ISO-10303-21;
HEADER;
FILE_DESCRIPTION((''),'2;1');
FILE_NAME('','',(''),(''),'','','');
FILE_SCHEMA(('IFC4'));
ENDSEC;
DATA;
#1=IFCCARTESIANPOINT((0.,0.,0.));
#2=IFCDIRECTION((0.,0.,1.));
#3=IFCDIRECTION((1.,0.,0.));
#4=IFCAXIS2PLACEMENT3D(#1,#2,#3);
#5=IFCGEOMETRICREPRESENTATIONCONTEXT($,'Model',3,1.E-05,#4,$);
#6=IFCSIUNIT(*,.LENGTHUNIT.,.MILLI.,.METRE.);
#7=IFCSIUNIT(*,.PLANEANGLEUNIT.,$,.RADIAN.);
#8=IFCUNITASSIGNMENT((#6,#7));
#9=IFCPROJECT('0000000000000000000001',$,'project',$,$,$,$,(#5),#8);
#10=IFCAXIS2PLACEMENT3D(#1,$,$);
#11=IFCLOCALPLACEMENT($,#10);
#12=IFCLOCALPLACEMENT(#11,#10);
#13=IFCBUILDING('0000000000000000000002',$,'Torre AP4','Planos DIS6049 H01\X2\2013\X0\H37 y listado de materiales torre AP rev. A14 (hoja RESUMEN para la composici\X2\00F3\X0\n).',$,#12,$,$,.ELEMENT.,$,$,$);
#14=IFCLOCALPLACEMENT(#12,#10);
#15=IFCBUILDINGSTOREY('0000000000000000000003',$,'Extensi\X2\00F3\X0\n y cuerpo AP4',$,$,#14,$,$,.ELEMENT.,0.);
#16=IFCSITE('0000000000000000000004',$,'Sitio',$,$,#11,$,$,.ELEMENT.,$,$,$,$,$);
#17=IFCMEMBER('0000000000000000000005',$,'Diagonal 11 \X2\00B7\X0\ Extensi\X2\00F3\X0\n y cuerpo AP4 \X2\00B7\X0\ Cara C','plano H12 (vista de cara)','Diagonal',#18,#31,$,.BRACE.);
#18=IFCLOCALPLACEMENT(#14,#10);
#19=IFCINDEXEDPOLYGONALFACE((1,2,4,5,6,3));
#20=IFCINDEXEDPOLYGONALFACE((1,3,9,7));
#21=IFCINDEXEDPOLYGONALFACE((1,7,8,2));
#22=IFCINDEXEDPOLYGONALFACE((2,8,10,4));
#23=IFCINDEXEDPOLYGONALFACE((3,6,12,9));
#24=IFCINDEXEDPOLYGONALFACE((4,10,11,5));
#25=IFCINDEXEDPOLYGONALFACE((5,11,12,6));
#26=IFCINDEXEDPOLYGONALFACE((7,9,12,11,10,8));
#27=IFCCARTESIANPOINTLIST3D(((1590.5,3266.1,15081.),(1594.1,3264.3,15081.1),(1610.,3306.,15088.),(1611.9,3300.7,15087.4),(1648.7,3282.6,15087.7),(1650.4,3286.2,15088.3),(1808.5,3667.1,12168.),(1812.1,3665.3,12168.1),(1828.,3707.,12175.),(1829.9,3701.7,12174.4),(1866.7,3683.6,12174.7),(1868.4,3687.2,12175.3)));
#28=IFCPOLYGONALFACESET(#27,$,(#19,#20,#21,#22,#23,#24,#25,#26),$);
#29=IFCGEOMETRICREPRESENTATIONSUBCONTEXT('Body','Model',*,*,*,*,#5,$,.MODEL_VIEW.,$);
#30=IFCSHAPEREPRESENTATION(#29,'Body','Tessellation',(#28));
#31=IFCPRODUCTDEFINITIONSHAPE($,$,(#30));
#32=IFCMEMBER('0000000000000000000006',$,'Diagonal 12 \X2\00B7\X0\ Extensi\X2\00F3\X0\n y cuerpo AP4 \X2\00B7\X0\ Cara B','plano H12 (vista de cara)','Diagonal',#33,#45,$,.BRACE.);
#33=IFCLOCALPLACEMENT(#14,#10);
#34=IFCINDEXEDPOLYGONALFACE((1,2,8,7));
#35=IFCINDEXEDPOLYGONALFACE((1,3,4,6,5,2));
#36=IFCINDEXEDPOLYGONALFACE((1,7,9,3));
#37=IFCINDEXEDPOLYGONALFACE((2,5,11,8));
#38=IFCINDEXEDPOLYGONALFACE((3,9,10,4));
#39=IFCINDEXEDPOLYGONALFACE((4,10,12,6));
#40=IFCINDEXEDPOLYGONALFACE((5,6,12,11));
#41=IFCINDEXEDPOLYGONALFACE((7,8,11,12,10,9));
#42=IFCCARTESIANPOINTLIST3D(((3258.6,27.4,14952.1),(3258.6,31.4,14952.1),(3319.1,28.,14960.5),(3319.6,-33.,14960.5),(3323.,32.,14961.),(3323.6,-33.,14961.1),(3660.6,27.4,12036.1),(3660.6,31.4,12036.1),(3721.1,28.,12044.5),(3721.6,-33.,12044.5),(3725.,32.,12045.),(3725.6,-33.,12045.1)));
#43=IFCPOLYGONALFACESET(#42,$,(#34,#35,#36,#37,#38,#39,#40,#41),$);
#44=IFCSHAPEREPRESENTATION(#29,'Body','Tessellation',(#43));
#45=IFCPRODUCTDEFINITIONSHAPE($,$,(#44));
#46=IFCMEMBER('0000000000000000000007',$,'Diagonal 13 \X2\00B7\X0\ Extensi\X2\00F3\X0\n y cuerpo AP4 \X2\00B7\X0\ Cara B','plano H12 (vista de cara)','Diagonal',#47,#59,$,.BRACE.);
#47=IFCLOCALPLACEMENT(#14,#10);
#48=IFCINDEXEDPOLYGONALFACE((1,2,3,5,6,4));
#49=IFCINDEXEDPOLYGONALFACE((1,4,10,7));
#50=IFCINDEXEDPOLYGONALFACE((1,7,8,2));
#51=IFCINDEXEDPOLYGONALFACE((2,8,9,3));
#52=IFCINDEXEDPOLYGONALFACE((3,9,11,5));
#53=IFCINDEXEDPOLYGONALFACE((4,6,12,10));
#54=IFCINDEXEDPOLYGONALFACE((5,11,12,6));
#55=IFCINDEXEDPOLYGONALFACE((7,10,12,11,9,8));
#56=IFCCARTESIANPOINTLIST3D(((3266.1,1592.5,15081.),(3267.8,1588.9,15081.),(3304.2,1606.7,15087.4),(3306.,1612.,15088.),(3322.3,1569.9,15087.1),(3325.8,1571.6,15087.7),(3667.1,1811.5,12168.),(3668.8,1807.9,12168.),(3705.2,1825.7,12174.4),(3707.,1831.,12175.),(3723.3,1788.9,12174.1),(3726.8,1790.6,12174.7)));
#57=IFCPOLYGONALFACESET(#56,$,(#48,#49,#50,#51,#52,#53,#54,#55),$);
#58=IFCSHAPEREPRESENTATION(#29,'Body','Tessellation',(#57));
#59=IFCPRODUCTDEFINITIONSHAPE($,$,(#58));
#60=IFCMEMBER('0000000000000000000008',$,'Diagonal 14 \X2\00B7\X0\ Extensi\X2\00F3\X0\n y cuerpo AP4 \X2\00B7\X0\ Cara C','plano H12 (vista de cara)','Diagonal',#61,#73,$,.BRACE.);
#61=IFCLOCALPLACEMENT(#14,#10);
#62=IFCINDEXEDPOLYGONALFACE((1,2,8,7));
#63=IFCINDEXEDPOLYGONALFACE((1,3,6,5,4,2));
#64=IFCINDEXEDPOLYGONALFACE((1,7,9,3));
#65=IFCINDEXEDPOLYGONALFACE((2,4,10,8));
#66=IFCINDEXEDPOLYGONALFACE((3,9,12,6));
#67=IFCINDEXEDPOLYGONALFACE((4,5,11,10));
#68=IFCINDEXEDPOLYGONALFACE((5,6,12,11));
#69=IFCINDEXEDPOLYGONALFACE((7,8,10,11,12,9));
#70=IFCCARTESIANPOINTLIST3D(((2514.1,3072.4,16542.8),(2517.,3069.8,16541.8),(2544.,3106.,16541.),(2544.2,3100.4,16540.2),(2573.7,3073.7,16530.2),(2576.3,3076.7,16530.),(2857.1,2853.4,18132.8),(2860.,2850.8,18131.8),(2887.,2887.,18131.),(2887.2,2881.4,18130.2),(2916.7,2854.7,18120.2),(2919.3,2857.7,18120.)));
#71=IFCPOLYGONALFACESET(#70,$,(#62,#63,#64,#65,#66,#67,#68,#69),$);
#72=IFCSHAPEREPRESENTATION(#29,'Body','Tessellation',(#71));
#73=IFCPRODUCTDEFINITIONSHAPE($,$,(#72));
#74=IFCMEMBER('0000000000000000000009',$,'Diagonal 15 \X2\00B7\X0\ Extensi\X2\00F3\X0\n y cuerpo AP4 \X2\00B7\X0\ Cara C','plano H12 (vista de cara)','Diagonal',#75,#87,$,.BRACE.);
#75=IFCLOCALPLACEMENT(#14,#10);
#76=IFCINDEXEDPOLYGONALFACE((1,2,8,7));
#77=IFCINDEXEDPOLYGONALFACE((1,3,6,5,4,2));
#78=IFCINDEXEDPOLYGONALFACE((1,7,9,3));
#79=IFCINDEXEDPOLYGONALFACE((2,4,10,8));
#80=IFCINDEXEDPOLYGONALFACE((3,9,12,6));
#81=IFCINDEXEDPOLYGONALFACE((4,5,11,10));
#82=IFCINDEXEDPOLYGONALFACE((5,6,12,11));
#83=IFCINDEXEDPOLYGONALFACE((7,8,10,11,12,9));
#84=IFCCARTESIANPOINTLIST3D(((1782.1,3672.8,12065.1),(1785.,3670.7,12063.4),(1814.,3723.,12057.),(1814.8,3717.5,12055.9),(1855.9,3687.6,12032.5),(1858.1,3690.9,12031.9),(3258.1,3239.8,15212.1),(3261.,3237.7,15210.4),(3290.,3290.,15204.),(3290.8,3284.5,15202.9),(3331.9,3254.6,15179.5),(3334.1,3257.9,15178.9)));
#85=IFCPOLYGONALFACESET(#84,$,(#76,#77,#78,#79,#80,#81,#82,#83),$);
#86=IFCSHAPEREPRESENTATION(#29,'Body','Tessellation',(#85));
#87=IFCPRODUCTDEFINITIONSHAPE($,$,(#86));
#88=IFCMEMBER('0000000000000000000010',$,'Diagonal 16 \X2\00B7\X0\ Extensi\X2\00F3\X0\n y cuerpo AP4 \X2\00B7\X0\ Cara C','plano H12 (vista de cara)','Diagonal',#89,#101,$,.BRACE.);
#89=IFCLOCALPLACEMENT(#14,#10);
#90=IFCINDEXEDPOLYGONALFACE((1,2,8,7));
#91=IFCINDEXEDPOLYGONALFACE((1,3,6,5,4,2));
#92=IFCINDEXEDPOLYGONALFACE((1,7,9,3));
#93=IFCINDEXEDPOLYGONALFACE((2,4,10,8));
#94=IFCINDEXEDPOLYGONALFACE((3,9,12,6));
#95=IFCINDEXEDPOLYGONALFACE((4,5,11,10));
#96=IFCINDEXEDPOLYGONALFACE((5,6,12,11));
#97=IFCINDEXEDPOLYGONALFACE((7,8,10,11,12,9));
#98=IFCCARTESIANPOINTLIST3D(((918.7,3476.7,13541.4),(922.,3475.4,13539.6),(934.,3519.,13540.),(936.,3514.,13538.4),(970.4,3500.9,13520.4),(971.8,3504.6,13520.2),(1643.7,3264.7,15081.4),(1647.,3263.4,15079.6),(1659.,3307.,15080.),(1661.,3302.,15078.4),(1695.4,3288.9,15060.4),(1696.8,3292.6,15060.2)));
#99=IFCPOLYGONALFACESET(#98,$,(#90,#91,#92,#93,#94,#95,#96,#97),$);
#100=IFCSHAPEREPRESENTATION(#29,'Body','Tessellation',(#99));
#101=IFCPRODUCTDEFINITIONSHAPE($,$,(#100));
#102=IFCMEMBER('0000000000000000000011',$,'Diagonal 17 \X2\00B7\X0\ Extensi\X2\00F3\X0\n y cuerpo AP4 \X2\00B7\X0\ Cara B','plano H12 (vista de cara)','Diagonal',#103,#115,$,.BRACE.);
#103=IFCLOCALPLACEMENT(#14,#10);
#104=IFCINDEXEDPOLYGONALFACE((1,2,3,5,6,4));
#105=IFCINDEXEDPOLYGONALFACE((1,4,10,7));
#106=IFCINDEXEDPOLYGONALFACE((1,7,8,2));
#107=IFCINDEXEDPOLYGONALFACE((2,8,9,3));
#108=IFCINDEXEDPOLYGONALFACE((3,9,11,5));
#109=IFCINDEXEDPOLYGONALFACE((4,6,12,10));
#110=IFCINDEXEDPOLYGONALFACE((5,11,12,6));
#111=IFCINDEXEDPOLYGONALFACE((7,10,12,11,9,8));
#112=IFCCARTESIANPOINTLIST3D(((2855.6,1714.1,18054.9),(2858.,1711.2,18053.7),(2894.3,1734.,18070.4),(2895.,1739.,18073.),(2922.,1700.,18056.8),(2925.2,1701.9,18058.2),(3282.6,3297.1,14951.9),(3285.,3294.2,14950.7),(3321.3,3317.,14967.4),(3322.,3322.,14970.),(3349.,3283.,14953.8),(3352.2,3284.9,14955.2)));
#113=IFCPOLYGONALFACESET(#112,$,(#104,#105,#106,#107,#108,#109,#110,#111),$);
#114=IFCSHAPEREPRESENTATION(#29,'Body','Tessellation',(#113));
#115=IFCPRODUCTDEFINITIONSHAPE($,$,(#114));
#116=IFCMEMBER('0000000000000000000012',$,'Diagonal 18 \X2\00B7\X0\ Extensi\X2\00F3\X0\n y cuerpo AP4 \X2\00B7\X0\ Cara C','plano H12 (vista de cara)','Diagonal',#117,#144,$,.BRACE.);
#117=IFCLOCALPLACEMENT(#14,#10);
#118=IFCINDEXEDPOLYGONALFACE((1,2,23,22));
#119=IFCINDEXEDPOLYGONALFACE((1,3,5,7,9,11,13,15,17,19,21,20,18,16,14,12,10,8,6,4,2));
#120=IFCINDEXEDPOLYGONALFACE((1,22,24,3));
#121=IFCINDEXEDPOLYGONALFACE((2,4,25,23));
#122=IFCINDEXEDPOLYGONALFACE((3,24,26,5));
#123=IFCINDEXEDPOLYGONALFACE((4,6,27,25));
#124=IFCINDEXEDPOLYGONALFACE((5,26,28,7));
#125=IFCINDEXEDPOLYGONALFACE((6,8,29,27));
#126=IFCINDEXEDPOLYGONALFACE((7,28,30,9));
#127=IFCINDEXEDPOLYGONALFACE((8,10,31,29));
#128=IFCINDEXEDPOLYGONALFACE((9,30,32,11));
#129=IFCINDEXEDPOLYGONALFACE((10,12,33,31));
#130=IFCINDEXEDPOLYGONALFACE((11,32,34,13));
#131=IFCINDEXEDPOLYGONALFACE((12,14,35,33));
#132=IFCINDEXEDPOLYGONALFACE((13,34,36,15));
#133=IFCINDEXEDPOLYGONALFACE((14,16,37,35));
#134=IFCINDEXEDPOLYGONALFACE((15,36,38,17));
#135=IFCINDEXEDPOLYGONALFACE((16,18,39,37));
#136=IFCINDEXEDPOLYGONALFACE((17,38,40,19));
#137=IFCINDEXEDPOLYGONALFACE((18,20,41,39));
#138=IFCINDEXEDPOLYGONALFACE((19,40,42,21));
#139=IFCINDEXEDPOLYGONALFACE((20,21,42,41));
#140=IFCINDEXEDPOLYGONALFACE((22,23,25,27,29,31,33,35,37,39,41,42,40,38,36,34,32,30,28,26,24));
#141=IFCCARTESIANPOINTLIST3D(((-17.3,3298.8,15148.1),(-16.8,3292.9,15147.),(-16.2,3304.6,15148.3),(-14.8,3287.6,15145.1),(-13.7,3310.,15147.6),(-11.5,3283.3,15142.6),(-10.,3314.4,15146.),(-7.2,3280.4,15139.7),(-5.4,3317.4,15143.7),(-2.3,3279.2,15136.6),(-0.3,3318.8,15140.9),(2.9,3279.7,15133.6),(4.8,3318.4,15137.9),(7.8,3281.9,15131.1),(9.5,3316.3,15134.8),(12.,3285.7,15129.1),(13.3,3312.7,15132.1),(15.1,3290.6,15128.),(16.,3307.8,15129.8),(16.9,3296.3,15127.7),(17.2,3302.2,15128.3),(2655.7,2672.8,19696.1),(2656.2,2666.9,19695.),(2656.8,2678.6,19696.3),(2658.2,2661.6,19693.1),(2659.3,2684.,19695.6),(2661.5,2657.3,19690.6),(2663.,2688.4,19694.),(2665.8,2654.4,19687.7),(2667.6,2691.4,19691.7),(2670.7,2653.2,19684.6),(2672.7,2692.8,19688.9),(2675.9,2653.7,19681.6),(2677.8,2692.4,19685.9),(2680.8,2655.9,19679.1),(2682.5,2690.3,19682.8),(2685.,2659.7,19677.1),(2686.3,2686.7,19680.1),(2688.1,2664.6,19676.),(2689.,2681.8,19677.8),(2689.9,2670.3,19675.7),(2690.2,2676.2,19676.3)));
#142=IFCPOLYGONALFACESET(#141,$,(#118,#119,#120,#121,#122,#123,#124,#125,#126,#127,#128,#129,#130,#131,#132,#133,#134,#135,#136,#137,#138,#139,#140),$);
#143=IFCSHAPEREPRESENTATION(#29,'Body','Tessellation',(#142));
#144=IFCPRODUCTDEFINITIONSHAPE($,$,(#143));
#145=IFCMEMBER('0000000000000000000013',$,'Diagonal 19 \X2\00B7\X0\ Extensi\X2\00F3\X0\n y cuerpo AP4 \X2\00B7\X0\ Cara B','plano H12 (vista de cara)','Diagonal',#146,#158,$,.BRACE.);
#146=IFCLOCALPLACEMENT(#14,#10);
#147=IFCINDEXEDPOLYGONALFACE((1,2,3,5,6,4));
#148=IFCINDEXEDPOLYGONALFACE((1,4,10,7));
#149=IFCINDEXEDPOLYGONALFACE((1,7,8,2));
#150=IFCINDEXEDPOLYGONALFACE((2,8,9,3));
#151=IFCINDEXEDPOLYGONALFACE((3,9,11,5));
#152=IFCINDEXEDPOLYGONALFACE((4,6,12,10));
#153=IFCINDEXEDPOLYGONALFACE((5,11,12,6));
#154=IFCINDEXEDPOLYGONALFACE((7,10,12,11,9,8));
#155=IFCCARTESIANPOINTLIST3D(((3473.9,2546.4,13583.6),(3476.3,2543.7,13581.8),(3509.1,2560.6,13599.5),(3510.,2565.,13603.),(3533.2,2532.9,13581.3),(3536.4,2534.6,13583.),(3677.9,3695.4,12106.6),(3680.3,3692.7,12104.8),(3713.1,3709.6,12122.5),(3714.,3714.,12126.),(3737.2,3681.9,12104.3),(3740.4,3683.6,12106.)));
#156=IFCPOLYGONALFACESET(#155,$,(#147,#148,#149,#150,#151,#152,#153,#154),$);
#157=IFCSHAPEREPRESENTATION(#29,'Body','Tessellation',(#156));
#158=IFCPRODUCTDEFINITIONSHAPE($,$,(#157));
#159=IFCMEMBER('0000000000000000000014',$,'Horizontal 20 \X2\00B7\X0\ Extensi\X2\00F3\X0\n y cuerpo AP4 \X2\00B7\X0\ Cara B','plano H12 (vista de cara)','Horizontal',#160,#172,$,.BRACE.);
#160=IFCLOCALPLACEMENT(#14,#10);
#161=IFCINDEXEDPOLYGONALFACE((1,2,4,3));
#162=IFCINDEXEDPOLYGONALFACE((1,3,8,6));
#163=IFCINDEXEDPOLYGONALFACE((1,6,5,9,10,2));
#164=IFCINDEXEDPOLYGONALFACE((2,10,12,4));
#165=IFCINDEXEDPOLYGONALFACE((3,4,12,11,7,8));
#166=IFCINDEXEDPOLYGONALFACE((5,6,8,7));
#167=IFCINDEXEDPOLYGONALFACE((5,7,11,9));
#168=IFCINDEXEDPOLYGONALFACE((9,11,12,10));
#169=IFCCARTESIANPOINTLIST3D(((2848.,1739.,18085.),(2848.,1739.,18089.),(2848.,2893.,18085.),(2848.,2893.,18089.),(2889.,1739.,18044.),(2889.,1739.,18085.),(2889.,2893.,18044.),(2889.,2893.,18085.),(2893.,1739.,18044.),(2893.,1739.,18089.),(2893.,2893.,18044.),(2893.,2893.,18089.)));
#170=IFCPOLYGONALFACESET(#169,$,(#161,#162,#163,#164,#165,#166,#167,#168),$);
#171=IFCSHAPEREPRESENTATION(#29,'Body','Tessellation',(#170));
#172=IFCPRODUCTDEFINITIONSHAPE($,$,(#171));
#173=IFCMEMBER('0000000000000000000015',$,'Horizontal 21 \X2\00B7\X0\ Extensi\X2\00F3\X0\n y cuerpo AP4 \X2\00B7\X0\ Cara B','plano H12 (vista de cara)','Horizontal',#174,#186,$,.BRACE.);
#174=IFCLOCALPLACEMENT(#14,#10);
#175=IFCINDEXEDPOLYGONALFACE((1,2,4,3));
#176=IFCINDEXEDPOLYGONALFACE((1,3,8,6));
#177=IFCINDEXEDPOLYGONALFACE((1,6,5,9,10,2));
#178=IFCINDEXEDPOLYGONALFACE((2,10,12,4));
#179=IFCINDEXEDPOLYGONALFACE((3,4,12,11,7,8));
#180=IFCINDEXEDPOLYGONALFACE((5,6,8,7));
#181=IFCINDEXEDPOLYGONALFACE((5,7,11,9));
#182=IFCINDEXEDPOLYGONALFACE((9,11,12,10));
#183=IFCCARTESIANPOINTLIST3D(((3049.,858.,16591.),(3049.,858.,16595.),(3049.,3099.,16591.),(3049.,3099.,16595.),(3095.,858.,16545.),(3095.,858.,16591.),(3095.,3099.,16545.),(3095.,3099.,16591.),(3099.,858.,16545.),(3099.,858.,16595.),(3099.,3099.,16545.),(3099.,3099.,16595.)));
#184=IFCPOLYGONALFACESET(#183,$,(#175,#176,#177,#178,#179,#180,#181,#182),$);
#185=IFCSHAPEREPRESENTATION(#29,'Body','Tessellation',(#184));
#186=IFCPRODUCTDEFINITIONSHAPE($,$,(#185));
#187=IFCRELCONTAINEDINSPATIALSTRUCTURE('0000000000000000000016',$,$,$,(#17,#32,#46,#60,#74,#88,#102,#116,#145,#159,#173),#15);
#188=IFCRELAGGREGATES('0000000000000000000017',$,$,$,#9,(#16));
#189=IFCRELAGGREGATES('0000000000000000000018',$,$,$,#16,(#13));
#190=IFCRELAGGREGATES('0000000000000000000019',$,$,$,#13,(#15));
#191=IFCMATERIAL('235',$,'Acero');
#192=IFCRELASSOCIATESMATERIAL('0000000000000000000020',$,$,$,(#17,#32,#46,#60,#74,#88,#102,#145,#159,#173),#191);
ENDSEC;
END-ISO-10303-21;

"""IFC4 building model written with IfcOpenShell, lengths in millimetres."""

from ifc_helpers import new_model, si_unit, frame, frame_2d, origin, origin_with_axes, place, context, subcontext, project, spatial, circle, l_section, extrude, material, element, save


model = new_model("IFC4")

# Units and contexts
model_context = context("Model", 3, precision=1e-05, world=origin_with_axes())
body_context = subcontext(model_context, "Body", "Model", "MODEL_VIEW")
ifc_project = project(units=[si_unit("LENGTHUNIT", "METRE", prefix="MILLI"), si_unit("PLANEANGLEUNIT", "RADIAN")], contexts=[model_context])

# Site, building, storey
site_placement = place(None, origin())
site = spatial("IfcSite", under=ifc_project, at=site_placement, Name="Sitio", CompositionType="ELEMENT")
building_placement = place(site_placement, origin())
building = spatial("IfcBuilding", under=site, at=building_placement, Name="Torre AP4", Description="Planos DIS6049 H01–H37 y listado de materiales torre AP rev. A14 (hoja RESUMEN para la composición).", CompositionType="ELEMENT")
storey_placement = place(building_placement, origin())
storey = spatial("IfcBuildingStorey", under=building, at=storey_placement, Name="Extensión y cuerpo AP4", CompositionType="ELEMENT", Elevation=0.0)

# Members
ifc_material_1 = material(Name="235", Category="Acero")
member_1_placement = place(storey_placement, frame((1828.0, 3707.0, 12175.0), z_axis=(-0.073935, -0.135999, 0.987946), x_axis=(-0.43397, -0.887553, -0.154657)))
element("IfcMember", 1, at=member_1_placement, inside=storey, material=ifc_material_1, Name="Diagonal 11 · Extensión y cuerpo AP4 · Cara C", Description="plano H12 (vista de cara)", ObjectType="Diagonal", PredefinedType="BRACE", context=body_context, shape_type="SweptSolid", body=[
    extrude(l_section(Depth=45.0, Width=45.0, Thickness=4.0, at=frame_2d((22.5, 22.5))), None, (0.0, 0.0, 1.0), 2948.5),
])
member_2_placement = place(storey_placement, frame((3725.0, 32.0, 12045.0), z_axis=(-0.136568, 0.0, 0.990631), x_axis=(-0.990589, -0.009166, -0.136563)))
element("IfcMember", 2, at=member_2_placement, inside=storey, material=ifc_material_1, Name="Diagonal 12 · Extensión y cuerpo AP4 · Cara B", Description="plano H12 (vista de cara)", ObjectType="Diagonal", PredefinedType="BRACE", context=body_context, shape_type="SweptSolid", body=[
    extrude(l_section(Depth=65.0, Width=65.0, Thickness=4.0, at=frame_2d((32.5, 32.5))), None, (0.0, 0.0, 1.0), 2943.6),
])
member_3_placement = place(storey_placement, frame((3707.0, 1831.0, 12175.0), z_axis=(-0.135996, -0.074272, 0.987921), x_axis=(-0.887298, -0.434439, -0.154806)))
element("IfcMember", 3, at=member_3_placement, inside=storey, material=ifc_material_1, Name="Diagonal 13 · Extensión y cuerpo AP4 · Cara B", Description="plano H12 (vista de cara)", ObjectType="Diagonal", PredefinedType="BRACE", context=body_context, shape_type="SweptSolid", body=[
    extrude(l_section(Depth=45.0, Width=45.0, Thickness=4.0, at=frame_2d((22.5, 22.5))), None, (0.0, 0.0, 1.0), 2948.6),
])
member_4_placement = place(storey_placement, frame((2544.0, 3106.0, 16541.0), z_axis=(0.208987, -0.133435, 0.968772), x_axis=(-0.663414, -0.747172, 0.040202)))
element("IfcMember", 4, at=member_4_placement, inside=storey, material=ifc_material_1, Name="Diagonal 14 · Extensión y cuerpo AP4 · Cara C", Description="plano H12 (vista de cara)", ObjectType="Diagonal", PredefinedType="BRACE", context=body_context, shape_type="SweptSolid", body=[
    extrude(l_section(Depth=45.0, Width=45.0, Thickness=4.0, at=frame_2d((22.5, 22.5))), None, (0.0, 0.0, 1.0), 1641.3),
])
member_5_placement = place(storey_placement, frame((1814.0, 3723.0, 12057.0), z_axis=(0.421376, -0.123615, 0.898422), x_axis=(-0.531937, -0.836041, 0.134456)))
element("IfcMember", 5, at=member_5_placement, inside=storey, material=ifc_material_1, Name="Diagonal 15 · Extensión y cuerpo AP4 · Cara C", Description="plano H12 (vista de cara)", ObjectType="Diagonal", PredefinedType="BRACE", context=body_context, shape_type="SweptSolid", body=[
    extrude(l_section(Depth=60.0, Width=60.0, Thickness=4.0, at=frame_2d((30.0, 30.0))), None, (0.0, 0.0, 1.0), 3502.8),
])
member_6_placement = place(storey_placement, frame((934.0, 3519.0, 13540.0), z_axis=(0.422673, -0.123595, 0.897815), x_axis=(-0.34071, -0.939656, 0.031044)))
element("IfcMember", 6, at=member_6_placement, inside=storey, material=ifc_material_1, Name="Diagonal 16 · Extensión y cuerpo AP4 · Cara C", Description="plano H12 (vista de cara)", ObjectType="Diagonal", PredefinedType="BRACE", context=body_context, shape_type="SweptSolid", body=[
    extrude(l_section(Depth=45.0, Width=45.0, Thickness=4.0, at=frame_2d((22.5, 22.5))), None, (0.0, 0.0, 1.0), 1715.3),
])
member_7_placement = place(storey_placement, frame((3322.0, 3322.0, 14970.0), z_axis=(-0.121669, -0.451057, 0.884163), x_axis=(-0.788239, -0.497452, -0.362244)))
element("IfcMember", 7, at=member_7_placement, inside=storey, material=ifc_material_1, Name="Diagonal 17 · Extensión y cuerpo AP4 · Cara B", Description="plano H12 (vista de cara)", ObjectType="Diagonal", PredefinedType="BRACE", context=body_context, shape_type="SweptSolid", body=[
    extrude(l_section(Depth=50.0, Width=50.0, Thickness=4.0, at=frame_2d((25.0, 25.0))), None, (0.0, 0.0, 1.0), 3509.5),
])
member_8_placement = place(storey_placement, frame((0.0, 3299.0, 15138.0), z_axis=(0.503167, -0.117839, 0.856118), x_axis=(-0.360959, -0.928763, 0.084309)))
element("IfcMember", 8, at=member_8_placement, inside=storey, Name="Diagonal 18 · Extensión y cuerpo AP4 · Cara C", Description="plano H12 (vista de cara)", ObjectType="Diagonal", PredefinedType="BRACE", context=body_context, shape_type="SweptSolid", body=[
    extrude(circle(Radius=20.0), None, (0.0, 0.0, 1.0), 5312.4),
])
member_9_placement = place(storey_placement, frame((3714.0, 3714.0, 12126.0), z_axis=(-0.108374, -0.610398, 0.784646), x_axis=(-0.801882, -0.412839, -0.431913)))
element("IfcMember", 9, at=member_9_placement, inside=storey, material=ifc_material_1, Name="Diagonal 19 · Extensión y cuerpo AP4 · Cara B", Description="plano H12 (vista de cara)", ObjectType="Diagonal", PredefinedType="BRACE", context=body_context, shape_type="SweptSolid", body=[
    extrude(l_section(Depth=45.0, Width=45.0, Thickness=4.0, at=frame_2d((22.5, 22.5))), None, (0.0, 0.0, 1.0), 1882.4),
])
member_10_placement = place(storey_placement, frame((2893.0, 2893.0, 18089.0), z_axis=(0.0, -1.0, 0.0), x_axis=(-1.0, 0.0, 0.0)))
element("IfcMember", 10, at=member_10_placement, inside=storey, material=ifc_material_1, Name="Horizontal 20 · Extensión y cuerpo AP4 · Cara B", Description="plano H12 (vista de cara)", ObjectType="Horizontal", PredefinedType="BRACE", context=body_context, shape_type="SweptSolid", body=[
    extrude(l_section(Depth=45.0, Width=45.0, Thickness=4.0, at=frame_2d((22.5, 22.5))), None, (0.0, 0.0, 1.0), 1154.0),
])
member_11_placement = place(storey_placement, frame((3099.0, 3099.0, 16595.0), z_axis=(0.0, -1.0, 0.0), x_axis=(-1.0, 0.0, 0.0)))
element("IfcMember", 11, at=member_11_placement, inside=storey, material=ifc_material_1, Name="Horizontal 21 · Extensión y cuerpo AP4 · Cara B", Description="plano H12 (vista de cara)", ObjectType="Horizontal", PredefinedType="BRACE", context=body_context, shape_type="SweptSolid", body=[
    extrude(l_section(Depth=50.0, Width=50.0, Thickness=4.0, at=frame_2d((25.0, 25.0))), None, (0.0, 0.0, 1.0), 2241.0),
])

save(model, "model.ifc")
